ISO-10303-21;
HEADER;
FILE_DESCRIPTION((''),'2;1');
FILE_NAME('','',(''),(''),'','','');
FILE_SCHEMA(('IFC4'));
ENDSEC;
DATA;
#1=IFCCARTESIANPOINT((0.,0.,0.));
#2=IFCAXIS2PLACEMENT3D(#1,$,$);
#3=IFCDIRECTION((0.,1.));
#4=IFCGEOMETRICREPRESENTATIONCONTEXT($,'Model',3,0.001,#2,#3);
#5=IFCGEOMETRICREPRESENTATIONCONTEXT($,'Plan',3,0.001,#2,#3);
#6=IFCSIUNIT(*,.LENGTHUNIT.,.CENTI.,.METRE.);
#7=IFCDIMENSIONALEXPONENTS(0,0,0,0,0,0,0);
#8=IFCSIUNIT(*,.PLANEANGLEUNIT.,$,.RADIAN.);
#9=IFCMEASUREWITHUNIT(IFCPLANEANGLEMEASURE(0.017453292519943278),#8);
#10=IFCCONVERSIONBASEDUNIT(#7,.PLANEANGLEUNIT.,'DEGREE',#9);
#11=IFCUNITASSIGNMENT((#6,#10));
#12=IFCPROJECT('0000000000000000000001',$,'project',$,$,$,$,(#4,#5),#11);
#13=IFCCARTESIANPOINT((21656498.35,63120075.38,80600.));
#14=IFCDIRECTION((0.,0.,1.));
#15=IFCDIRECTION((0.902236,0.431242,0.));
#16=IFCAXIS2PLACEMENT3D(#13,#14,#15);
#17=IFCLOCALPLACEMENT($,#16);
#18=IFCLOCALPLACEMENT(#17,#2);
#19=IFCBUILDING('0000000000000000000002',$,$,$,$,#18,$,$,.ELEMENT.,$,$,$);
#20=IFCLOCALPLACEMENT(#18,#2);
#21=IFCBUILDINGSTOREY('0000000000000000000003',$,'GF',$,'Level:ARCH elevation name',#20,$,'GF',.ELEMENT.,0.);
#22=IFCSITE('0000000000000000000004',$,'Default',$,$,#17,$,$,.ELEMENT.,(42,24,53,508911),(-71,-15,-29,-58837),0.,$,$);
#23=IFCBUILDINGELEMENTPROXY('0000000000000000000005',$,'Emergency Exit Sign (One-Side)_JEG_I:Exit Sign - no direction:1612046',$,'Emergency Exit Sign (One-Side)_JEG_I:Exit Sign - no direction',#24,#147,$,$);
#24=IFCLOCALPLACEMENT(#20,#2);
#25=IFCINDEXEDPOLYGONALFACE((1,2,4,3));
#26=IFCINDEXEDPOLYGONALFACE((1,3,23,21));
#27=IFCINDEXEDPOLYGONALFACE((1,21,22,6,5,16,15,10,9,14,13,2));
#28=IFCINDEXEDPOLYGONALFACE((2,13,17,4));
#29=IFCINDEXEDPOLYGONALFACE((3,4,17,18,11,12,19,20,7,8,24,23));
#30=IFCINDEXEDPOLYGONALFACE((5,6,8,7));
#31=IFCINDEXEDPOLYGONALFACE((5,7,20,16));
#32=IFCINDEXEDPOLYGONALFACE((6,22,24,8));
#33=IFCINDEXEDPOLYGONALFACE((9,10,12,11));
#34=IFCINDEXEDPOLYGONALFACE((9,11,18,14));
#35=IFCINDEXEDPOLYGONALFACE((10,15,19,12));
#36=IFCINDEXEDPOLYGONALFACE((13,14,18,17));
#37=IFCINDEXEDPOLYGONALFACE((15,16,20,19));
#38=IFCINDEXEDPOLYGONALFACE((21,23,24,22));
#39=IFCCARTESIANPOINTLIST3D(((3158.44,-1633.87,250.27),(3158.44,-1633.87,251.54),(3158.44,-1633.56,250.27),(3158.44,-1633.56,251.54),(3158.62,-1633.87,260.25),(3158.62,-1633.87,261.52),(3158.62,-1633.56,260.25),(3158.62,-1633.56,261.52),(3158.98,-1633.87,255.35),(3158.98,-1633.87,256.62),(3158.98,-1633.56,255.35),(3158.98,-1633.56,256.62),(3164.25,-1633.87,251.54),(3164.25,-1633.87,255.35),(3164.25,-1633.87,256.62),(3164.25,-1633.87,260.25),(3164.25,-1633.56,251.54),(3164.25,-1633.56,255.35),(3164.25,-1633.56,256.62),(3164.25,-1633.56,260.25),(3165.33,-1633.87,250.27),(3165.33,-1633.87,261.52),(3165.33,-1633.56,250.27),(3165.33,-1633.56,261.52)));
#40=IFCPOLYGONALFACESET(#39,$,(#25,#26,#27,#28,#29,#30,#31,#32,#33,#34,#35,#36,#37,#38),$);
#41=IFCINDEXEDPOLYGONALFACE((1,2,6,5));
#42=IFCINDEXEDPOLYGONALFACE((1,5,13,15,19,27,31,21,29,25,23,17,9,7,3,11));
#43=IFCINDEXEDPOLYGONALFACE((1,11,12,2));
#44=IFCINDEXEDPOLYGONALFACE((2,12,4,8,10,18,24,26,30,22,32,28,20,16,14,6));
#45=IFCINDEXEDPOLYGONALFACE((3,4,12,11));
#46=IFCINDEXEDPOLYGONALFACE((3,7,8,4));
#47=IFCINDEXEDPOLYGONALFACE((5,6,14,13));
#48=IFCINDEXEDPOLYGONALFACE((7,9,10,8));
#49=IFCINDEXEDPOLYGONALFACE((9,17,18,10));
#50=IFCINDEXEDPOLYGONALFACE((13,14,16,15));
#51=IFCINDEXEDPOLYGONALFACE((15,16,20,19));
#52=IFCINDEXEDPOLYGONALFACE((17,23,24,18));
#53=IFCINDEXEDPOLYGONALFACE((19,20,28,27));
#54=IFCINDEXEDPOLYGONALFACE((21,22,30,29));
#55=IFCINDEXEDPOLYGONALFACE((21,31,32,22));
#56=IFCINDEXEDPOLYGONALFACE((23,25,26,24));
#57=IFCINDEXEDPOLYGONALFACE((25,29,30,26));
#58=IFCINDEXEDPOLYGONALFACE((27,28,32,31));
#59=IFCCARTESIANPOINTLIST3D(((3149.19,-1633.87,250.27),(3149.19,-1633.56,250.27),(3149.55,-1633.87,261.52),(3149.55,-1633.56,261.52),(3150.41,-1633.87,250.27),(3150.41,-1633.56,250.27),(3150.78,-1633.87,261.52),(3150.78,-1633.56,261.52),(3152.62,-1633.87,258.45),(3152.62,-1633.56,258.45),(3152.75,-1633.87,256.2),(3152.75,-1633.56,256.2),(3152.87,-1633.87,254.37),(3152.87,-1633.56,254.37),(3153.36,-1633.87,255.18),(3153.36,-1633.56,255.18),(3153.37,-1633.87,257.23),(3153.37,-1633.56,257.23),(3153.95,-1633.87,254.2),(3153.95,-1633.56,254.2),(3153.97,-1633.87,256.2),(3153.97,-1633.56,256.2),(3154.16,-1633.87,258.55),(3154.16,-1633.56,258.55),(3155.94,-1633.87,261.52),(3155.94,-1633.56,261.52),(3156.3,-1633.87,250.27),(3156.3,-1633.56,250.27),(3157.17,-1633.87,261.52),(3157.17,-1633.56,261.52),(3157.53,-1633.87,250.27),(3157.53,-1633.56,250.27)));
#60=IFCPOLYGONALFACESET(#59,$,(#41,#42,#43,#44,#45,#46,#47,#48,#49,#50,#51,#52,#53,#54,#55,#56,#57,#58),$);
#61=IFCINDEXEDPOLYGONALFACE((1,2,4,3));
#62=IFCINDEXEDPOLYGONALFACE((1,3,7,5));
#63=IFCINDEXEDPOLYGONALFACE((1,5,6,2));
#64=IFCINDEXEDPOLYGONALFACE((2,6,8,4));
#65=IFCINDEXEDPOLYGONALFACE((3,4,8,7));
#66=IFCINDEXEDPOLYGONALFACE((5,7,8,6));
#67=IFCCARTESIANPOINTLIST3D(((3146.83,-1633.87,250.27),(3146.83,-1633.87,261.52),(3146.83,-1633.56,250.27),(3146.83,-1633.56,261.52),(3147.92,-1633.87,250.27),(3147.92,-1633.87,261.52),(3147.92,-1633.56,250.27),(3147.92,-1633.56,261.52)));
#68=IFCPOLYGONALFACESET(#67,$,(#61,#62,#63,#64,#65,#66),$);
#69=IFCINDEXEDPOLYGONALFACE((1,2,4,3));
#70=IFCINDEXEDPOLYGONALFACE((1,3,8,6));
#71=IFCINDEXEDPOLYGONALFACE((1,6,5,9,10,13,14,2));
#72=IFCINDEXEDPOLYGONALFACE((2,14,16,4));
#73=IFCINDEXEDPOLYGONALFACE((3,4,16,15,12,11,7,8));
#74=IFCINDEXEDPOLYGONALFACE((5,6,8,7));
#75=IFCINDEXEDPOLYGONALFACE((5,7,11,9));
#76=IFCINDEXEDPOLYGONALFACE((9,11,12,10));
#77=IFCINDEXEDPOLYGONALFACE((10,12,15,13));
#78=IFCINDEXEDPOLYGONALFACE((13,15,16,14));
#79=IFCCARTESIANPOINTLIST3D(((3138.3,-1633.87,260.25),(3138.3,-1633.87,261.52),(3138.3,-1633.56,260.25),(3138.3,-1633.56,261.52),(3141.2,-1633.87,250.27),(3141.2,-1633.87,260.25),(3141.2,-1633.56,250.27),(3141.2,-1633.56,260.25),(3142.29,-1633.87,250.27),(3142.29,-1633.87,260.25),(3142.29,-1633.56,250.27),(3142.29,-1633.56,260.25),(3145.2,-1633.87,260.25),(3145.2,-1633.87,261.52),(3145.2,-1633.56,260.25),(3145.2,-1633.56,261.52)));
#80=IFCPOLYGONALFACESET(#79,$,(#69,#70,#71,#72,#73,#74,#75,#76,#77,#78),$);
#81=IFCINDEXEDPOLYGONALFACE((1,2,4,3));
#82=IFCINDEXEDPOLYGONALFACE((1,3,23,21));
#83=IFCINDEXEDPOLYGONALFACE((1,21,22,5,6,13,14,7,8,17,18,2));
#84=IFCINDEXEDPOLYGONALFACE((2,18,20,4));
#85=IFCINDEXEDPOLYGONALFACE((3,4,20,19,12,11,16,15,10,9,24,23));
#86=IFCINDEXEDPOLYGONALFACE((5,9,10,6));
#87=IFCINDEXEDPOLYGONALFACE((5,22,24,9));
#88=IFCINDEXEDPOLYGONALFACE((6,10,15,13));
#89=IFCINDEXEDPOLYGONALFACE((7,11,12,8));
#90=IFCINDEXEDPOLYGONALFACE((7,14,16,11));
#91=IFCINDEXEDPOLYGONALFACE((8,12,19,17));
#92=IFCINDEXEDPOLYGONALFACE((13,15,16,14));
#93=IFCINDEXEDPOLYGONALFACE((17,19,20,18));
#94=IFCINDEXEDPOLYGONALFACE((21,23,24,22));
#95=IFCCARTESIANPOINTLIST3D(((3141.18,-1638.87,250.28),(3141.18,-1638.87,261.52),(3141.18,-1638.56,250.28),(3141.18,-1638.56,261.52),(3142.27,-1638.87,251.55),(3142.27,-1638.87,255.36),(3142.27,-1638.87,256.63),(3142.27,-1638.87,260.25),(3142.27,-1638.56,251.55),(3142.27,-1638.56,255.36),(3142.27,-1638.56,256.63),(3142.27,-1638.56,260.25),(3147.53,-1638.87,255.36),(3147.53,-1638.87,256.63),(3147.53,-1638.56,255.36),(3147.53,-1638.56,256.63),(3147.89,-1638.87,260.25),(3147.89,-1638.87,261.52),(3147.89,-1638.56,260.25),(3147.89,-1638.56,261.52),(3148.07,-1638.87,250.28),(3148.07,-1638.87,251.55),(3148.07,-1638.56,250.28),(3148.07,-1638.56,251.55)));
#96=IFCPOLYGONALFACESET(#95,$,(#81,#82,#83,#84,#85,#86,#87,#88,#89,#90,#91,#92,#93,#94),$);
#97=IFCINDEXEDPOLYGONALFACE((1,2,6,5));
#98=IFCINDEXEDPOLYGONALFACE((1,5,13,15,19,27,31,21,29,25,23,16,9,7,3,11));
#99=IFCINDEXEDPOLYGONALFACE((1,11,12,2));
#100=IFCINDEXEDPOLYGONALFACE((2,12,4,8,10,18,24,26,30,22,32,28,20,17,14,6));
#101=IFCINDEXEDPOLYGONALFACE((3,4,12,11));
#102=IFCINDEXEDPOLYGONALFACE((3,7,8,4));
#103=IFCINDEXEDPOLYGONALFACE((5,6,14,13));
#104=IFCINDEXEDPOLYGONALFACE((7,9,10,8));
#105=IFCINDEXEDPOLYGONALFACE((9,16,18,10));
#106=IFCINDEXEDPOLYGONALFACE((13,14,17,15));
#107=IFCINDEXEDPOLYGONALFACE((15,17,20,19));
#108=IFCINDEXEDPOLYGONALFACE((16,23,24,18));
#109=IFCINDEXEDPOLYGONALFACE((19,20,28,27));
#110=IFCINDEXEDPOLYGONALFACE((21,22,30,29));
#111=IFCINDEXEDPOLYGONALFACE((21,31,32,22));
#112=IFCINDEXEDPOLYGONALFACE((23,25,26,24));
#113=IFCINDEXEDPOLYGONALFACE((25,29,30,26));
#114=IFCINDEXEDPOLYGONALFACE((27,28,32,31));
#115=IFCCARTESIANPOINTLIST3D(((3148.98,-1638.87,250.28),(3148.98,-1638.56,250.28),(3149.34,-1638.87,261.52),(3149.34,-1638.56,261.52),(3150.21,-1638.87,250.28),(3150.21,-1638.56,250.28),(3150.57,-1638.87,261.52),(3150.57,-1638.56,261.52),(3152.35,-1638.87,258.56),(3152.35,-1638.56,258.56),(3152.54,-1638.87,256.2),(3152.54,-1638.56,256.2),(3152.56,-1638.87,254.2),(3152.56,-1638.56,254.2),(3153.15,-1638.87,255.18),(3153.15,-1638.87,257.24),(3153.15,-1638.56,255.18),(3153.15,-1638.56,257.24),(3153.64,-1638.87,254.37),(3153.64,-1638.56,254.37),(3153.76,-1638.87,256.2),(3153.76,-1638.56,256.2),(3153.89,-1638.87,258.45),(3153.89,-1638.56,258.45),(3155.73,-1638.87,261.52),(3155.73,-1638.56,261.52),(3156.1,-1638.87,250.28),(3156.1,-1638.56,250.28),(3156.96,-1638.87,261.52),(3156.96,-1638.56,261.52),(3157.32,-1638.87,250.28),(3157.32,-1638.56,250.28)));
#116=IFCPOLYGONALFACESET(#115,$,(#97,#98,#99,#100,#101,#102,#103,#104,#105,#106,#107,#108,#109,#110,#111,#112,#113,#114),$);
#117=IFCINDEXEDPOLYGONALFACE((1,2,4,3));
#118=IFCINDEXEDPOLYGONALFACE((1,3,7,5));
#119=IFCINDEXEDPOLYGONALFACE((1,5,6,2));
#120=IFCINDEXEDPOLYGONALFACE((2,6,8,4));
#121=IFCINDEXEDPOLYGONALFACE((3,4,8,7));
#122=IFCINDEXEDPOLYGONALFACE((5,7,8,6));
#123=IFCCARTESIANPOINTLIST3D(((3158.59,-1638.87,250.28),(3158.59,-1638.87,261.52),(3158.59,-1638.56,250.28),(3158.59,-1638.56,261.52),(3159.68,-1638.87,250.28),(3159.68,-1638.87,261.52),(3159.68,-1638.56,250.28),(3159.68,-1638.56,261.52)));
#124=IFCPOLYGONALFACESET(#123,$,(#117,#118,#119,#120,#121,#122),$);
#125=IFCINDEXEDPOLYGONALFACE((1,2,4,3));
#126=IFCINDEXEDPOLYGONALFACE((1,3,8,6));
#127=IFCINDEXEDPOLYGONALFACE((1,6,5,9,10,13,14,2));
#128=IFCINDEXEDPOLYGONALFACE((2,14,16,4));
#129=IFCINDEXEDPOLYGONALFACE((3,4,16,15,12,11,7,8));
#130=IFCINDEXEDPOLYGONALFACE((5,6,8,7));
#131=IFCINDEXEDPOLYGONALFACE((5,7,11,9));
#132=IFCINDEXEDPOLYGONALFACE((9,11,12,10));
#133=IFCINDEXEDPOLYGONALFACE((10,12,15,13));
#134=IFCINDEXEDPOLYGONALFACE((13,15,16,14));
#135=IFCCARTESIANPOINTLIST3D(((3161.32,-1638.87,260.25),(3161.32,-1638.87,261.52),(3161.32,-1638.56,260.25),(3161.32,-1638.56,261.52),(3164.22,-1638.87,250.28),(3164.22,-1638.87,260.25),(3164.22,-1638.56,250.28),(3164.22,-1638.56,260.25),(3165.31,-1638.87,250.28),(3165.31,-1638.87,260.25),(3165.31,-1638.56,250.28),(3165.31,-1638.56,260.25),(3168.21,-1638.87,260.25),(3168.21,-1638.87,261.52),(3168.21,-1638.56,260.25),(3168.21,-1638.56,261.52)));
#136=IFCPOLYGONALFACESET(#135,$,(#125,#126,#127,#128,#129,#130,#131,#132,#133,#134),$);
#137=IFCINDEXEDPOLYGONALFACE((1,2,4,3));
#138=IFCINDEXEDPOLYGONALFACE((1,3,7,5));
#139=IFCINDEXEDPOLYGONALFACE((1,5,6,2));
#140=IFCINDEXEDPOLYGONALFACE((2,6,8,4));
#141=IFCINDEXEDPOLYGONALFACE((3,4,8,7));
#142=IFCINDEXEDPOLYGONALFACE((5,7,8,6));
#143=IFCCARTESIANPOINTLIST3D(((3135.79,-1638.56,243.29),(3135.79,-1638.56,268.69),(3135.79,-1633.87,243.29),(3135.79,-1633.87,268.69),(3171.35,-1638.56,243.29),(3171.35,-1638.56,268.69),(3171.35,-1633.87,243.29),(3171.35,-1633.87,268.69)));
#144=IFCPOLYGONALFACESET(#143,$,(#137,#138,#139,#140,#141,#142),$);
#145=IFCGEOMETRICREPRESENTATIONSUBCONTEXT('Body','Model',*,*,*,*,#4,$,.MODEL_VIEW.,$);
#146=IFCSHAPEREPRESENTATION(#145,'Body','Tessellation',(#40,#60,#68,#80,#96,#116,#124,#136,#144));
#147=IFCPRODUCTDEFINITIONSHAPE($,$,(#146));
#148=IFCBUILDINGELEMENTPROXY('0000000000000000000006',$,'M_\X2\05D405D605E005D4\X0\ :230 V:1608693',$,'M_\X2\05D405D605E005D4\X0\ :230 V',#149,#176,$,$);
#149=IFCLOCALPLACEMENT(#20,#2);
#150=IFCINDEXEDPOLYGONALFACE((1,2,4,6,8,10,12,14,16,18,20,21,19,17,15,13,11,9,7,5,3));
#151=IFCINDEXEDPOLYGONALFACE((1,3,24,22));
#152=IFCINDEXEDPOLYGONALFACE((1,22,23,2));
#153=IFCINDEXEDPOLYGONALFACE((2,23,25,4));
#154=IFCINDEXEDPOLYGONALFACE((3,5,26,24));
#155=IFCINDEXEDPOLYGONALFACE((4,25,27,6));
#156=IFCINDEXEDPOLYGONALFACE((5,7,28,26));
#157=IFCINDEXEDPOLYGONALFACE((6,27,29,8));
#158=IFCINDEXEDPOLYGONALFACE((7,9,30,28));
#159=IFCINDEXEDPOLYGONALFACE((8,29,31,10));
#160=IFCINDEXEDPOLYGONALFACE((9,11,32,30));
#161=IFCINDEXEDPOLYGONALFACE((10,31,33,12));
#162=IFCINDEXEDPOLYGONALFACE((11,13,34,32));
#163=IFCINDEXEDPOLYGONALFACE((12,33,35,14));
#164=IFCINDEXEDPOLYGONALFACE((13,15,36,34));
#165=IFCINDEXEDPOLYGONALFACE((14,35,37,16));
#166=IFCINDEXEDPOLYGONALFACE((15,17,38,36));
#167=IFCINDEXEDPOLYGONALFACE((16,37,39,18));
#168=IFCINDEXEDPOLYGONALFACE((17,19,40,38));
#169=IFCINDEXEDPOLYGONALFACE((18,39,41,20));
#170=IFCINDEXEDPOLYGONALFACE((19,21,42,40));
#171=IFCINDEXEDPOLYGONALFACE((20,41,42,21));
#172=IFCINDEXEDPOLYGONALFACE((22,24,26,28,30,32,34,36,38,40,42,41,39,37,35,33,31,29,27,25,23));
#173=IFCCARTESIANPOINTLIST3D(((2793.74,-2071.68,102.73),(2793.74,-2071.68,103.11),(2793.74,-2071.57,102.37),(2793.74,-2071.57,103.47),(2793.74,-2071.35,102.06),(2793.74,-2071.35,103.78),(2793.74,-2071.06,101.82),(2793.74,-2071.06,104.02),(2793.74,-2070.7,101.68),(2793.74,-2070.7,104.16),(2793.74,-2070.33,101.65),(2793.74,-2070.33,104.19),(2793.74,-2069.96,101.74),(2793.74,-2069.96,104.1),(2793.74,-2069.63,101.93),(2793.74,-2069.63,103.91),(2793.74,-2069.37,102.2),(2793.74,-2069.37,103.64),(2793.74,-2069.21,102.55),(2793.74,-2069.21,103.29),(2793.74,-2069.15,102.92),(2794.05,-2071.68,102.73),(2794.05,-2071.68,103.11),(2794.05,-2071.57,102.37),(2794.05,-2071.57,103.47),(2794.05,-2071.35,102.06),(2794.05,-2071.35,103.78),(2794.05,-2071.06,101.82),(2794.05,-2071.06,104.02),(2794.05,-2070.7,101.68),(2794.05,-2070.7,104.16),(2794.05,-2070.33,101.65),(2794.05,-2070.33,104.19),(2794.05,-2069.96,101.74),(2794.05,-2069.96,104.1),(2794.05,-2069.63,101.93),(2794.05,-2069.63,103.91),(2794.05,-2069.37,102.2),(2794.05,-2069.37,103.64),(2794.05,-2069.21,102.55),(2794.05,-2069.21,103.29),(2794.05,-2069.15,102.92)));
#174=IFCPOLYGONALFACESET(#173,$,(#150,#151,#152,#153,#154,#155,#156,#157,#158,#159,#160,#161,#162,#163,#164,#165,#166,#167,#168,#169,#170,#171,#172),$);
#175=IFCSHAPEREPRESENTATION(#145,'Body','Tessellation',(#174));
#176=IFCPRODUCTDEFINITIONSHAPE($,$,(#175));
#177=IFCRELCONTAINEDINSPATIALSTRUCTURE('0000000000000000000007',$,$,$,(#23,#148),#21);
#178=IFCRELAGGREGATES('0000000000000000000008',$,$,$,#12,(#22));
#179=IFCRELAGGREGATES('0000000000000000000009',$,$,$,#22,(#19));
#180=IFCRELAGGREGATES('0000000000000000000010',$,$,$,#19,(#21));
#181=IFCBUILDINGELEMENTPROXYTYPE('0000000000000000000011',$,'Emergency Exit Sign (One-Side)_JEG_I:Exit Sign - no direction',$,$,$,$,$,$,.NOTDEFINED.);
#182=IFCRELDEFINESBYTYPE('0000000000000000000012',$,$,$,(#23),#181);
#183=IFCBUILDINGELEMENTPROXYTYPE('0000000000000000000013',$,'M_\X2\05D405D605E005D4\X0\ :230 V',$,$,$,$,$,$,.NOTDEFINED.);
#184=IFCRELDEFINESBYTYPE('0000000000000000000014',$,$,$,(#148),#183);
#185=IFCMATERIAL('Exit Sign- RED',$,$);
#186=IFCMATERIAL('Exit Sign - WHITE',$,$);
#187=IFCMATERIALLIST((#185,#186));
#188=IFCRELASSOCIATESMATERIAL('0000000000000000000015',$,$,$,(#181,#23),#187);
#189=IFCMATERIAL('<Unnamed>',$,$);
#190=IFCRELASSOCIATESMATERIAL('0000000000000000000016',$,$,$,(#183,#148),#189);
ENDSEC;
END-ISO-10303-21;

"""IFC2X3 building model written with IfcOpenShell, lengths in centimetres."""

from ifc_helpers import new_model, entity, si_unit, converted_unit, direction, frame, frame_2d, origin, origin_2d_with_axis, place, context, subcontext, project, spatial, polyline, rectangle, circle, outline, extrude, source, transform, mapped, material, material_list, type_object, type_shapes, element, save


model = new_model("IFC2X3")

# Units and contexts
model_context = context("Model", 3, precision=0.001, world=origin(), true_north=direction((0.0, 1.0)))
plan_context = context("Plan", 3, precision=0.001, world=origin(), true_north=direction((0.0, 1.0)))
body_context = subcontext(model_context, "Body", "Model", "MODEL_VIEW")
ifc_project = project(units=[si_unit("LENGTHUNIT", "METRE", prefix="CENTI"), converted_unit("PLANEANGLEUNIT", "DEGREE", entity("IfcPlaneAngleMeasure", 0.017453292519943278), si_unit("PLANEANGLEUNIT", "RADIAN"), dimensions=[0, 0, 0, 0, 0, 0, 0])], contexts=[model_context, plan_context])

# Site, building, storey
site_placement = place(None, frame((21656498.35, 63120075.38, 80600.0), z_axis=(0.0, 0.0, 1.0), x_axis=(0.902236, 0.431242, 0.0)))
site = spatial("IfcSite", under=ifc_project, at=site_placement, Name="Default", CompositionType="ELEMENT", RefLatitude=(42, 24, 53, 508911), RefLongitude=(-71, -15, -29, -58837), RefElevation=0.0)
building_placement = place(site_placement, origin())
building = spatial("IfcBuilding", under=site, at=building_placement, CompositionType="ELEMENT")
storey_placement = place(building_placement, origin())
storey = spatial("IfcBuildingStorey", under=building, at=storey_placement, Name="GF", ObjectType="Level:ARCH elevation name", LongName="GF", CompositionType="ELEMENT", Elevation=0.0)

# Building element proxies
ifc_material_1 = material(Name="<Unnamed>")
ifc_material_2 = material(Name="Exit Sign- RED")
ifc_material_3 = material(Name="Exit Sign - WHITE")
ifc_material_list_1 = material_list([ifc_material_2, ifc_material_3])
building_element_proxy_type_1 = type_object("IfcBuildingElementProxyType", Name="Emergency Exit Sign (One-Side)_JEG_I:Exit Sign - no direction", PredefinedType="NOTDEFINED", material=ifc_material_list_1)
shared_shape_1 = source(origin(), body_context, "Body", "SweptSolid", [
    extrude(outline(polyline([(-5.65, -3.69), (5.59, -3.69), (5.59, 3.02), (4.32, 3.02), (4.32, -2.6), (0.7, -2.6), (0.7, 2.66), (-0.57, 2.66), (-0.57, -2.6), (-4.38, -2.6), (-4.38, 3.21), (-5.65, 3.21), (-5.65, -3.69)])), frame((-8.08, -5.22, 12.64), z_axis=(0.0, 1.0, 0.0), x_axis=(0.0, 0.0, 1.0)), (0.0, 0.0, 1.0), 0.32),
    extrude(outline(polyline([(-7.14, 0.57), (-6.5, -0.49), (-1.93, -0.48), (-0.78, -0.48), (-1.23, -1.32), (-3.47, -5.53), (-2.84, -6.59), (0.41, -0.48), (6.62, -0.48), (5.99, 0.57), (2.4, 0.57), (0.98, 0.58), (1.7, 1.94), (3.32, 5.0), (2.69, 6.05), (-0.22, 0.57), (-7.14, 0.57)])), frame((0.2, -5.22, 12.81), z_axis=(0.0, -1.0, 0.0), x_axis=(0.515099, 0.0, 0.857131)), (0.0, 0.0, -1.0), 0.32),
    extrude(rectangle(XDim=0.32, YDim=1.09, at=frame_2d((0.0, 0.0), x_axis=(1.0, 0.0))), frame((6.19, -5.06, 6.99), z_axis=(0.0, 0.0, 1.0), x_axis=(0.0, 1.0, 0.0)), (0.0, 0.0, 1.0), 11.25),
    extrude(outline(polyline([(-7.8, 0.54), (-7.8, -0.54), (2.18, -0.54), (2.18, -3.45), (3.45, -3.45), (3.45, 3.45), (2.18, 3.45), (2.18, 0.54), (-7.8, 0.54)])), frame((11.82, -5.22, 14.79), z_axis=(0.0, -1.0, 0.0), x_axis=(0.0, 0.0, 1.0)), (0.0, 0.0, -1.0), 0.32),
    extrude(outline(polyline([(-3.69, -5.65), (3.21, -5.65), (3.21, -4.38), (-2.6, -4.38), (-2.6, -0.57), (2.66, -0.57), (2.66, 0.7), (-2.6, 0.7), (-2.6, 4.32), (3.02, 4.32), (3.02, 5.59), (-3.69, 5.59), (-3.69, -5.65)])), frame((8.7, -0.22, 12.65), z_axis=(0.0, 1.0, 0.0), x_axis=(-1.0, 0.0, 0.0)), (0.0, 0.0, 1.0), 0.32),
    extrude(outline(polyline([(-4.16, -5.82), (-2.93, -5.82), (-0.58, -1.9), (0.01, -0.92), (0.5, -1.73), (2.96, -5.82), (4.18, -5.82), (0.62, 0.1), (3.82, 5.42), (2.59, 5.42), (0.75, 2.35), (0.01, 1.14), (-0.79, 2.46), (-2.57, 5.42), (-3.8, 5.42), (-0.6, 0.1), (-4.16, -5.82)])), frame((0.43, -0.22, 12.82), z_axis=(0.0, 1.0, 0.0), x_axis=(-1.0, 0.0, 0.0)), (0.0, 0.0, 1.0), 0.32),
    extrude(rectangle(XDim=0.32, YDim=1.09, at=origin_2d_with_axis()), frame((-5.57, -0.06, 6.99), z_axis=(0.0, 0.0, 1.0), x_axis=(0.0, -1.0, 0.0)), (0.0, 0.0, 1.0), 11.25),
    extrude(outline(polyline([(-0.54, -7.8), (0.54, -7.8), (0.54, 2.18), (3.45, 2.18), (3.45, 3.45), (-3.45, 3.45), (-3.45, 2.18), (-0.54, 2.18), (-0.54, -7.8)])), frame((-11.2, -0.22, 14.79), z_axis=(0.0, 1.0, 0.0), x_axis=(-1.0, 0.0, 0.0)), (0.0, 0.0, 1.0), 0.32),
    extrude(rectangle(XDim=4.68, YDim=35.56, at=origin_2d_with_axis()), frame((0.0, -2.56, 0.01), z_axis=(0.0, 0.0, 1.0), x_axis=(0.0, 1.0, 0.0)), (0.0, 0.0, 1.0), 25.4),
])
type_shapes(building_element_proxy_type_1, [shared_shape_1])
for number, where, z_axis, x_axis, name in (
    (1, (3153.57, -1638.78, 243.28), (0.0, 0.0, 1.0), (-1.0, 0.0, 0.0), "Emergency Exit Sign (One-Side)_JEG_I:Exit Sign - no direction:1612046"),
):
    element("IfcBuildingElementProxy", number, at=place(storey_placement, frame(where, z_axis=z_axis, x_axis=x_axis)), inside=storey, type_object=building_element_proxy_type_1, material=ifc_material_list_1, Name=name, ObjectType="Emergency Exit Sign (One-Side)_JEG_I:Exit Sign - no direction", context=body_context, shape_type="MappedRepresentation", body=[
        mapped(shared_shape_1, transform((0.0, 0.0, 0.0), scale=1.0)),
    ])
building_element_proxy_type_2 = type_object("IfcBuildingElementProxyType", Name="M_הזנה :230 V", PredefinedType="NOTDEFINED", material=ifc_material_1)
shared_shape_2 = source(origin(), body_context, "Body", "SweptSolid", [
    extrude(circle(Radius=1.27, at=frame_2d((0.0, 0.0), x_axis=(1.0, 0.0))), origin(), (0.0, 0.0, 1.0), 0.32),
])
type_shapes(building_element_proxy_type_2, [shared_shape_2])
for number, where, z_axis, x_axis, name in (
    (2, (2793.74, -2070.42, 102.92), (1.0, 0.0, 0.0), (0.0, 1.0, 0.0), "M_הזנה :230 V:1608693"),
):
    element("IfcBuildingElementProxy", number, at=place(storey_placement, frame(where, z_axis=z_axis, x_axis=x_axis)), inside=storey, type_object=building_element_proxy_type_2, material=ifc_material_1, Name=name, ObjectType="M_הזנה :230 V", context=body_context, shape_type="MappedRepresentation", body=[
        mapped(shared_shape_2, transform((0.0, 0.0, 0.0), scale=1.0)),
    ])

save(model, "model.ifc")
